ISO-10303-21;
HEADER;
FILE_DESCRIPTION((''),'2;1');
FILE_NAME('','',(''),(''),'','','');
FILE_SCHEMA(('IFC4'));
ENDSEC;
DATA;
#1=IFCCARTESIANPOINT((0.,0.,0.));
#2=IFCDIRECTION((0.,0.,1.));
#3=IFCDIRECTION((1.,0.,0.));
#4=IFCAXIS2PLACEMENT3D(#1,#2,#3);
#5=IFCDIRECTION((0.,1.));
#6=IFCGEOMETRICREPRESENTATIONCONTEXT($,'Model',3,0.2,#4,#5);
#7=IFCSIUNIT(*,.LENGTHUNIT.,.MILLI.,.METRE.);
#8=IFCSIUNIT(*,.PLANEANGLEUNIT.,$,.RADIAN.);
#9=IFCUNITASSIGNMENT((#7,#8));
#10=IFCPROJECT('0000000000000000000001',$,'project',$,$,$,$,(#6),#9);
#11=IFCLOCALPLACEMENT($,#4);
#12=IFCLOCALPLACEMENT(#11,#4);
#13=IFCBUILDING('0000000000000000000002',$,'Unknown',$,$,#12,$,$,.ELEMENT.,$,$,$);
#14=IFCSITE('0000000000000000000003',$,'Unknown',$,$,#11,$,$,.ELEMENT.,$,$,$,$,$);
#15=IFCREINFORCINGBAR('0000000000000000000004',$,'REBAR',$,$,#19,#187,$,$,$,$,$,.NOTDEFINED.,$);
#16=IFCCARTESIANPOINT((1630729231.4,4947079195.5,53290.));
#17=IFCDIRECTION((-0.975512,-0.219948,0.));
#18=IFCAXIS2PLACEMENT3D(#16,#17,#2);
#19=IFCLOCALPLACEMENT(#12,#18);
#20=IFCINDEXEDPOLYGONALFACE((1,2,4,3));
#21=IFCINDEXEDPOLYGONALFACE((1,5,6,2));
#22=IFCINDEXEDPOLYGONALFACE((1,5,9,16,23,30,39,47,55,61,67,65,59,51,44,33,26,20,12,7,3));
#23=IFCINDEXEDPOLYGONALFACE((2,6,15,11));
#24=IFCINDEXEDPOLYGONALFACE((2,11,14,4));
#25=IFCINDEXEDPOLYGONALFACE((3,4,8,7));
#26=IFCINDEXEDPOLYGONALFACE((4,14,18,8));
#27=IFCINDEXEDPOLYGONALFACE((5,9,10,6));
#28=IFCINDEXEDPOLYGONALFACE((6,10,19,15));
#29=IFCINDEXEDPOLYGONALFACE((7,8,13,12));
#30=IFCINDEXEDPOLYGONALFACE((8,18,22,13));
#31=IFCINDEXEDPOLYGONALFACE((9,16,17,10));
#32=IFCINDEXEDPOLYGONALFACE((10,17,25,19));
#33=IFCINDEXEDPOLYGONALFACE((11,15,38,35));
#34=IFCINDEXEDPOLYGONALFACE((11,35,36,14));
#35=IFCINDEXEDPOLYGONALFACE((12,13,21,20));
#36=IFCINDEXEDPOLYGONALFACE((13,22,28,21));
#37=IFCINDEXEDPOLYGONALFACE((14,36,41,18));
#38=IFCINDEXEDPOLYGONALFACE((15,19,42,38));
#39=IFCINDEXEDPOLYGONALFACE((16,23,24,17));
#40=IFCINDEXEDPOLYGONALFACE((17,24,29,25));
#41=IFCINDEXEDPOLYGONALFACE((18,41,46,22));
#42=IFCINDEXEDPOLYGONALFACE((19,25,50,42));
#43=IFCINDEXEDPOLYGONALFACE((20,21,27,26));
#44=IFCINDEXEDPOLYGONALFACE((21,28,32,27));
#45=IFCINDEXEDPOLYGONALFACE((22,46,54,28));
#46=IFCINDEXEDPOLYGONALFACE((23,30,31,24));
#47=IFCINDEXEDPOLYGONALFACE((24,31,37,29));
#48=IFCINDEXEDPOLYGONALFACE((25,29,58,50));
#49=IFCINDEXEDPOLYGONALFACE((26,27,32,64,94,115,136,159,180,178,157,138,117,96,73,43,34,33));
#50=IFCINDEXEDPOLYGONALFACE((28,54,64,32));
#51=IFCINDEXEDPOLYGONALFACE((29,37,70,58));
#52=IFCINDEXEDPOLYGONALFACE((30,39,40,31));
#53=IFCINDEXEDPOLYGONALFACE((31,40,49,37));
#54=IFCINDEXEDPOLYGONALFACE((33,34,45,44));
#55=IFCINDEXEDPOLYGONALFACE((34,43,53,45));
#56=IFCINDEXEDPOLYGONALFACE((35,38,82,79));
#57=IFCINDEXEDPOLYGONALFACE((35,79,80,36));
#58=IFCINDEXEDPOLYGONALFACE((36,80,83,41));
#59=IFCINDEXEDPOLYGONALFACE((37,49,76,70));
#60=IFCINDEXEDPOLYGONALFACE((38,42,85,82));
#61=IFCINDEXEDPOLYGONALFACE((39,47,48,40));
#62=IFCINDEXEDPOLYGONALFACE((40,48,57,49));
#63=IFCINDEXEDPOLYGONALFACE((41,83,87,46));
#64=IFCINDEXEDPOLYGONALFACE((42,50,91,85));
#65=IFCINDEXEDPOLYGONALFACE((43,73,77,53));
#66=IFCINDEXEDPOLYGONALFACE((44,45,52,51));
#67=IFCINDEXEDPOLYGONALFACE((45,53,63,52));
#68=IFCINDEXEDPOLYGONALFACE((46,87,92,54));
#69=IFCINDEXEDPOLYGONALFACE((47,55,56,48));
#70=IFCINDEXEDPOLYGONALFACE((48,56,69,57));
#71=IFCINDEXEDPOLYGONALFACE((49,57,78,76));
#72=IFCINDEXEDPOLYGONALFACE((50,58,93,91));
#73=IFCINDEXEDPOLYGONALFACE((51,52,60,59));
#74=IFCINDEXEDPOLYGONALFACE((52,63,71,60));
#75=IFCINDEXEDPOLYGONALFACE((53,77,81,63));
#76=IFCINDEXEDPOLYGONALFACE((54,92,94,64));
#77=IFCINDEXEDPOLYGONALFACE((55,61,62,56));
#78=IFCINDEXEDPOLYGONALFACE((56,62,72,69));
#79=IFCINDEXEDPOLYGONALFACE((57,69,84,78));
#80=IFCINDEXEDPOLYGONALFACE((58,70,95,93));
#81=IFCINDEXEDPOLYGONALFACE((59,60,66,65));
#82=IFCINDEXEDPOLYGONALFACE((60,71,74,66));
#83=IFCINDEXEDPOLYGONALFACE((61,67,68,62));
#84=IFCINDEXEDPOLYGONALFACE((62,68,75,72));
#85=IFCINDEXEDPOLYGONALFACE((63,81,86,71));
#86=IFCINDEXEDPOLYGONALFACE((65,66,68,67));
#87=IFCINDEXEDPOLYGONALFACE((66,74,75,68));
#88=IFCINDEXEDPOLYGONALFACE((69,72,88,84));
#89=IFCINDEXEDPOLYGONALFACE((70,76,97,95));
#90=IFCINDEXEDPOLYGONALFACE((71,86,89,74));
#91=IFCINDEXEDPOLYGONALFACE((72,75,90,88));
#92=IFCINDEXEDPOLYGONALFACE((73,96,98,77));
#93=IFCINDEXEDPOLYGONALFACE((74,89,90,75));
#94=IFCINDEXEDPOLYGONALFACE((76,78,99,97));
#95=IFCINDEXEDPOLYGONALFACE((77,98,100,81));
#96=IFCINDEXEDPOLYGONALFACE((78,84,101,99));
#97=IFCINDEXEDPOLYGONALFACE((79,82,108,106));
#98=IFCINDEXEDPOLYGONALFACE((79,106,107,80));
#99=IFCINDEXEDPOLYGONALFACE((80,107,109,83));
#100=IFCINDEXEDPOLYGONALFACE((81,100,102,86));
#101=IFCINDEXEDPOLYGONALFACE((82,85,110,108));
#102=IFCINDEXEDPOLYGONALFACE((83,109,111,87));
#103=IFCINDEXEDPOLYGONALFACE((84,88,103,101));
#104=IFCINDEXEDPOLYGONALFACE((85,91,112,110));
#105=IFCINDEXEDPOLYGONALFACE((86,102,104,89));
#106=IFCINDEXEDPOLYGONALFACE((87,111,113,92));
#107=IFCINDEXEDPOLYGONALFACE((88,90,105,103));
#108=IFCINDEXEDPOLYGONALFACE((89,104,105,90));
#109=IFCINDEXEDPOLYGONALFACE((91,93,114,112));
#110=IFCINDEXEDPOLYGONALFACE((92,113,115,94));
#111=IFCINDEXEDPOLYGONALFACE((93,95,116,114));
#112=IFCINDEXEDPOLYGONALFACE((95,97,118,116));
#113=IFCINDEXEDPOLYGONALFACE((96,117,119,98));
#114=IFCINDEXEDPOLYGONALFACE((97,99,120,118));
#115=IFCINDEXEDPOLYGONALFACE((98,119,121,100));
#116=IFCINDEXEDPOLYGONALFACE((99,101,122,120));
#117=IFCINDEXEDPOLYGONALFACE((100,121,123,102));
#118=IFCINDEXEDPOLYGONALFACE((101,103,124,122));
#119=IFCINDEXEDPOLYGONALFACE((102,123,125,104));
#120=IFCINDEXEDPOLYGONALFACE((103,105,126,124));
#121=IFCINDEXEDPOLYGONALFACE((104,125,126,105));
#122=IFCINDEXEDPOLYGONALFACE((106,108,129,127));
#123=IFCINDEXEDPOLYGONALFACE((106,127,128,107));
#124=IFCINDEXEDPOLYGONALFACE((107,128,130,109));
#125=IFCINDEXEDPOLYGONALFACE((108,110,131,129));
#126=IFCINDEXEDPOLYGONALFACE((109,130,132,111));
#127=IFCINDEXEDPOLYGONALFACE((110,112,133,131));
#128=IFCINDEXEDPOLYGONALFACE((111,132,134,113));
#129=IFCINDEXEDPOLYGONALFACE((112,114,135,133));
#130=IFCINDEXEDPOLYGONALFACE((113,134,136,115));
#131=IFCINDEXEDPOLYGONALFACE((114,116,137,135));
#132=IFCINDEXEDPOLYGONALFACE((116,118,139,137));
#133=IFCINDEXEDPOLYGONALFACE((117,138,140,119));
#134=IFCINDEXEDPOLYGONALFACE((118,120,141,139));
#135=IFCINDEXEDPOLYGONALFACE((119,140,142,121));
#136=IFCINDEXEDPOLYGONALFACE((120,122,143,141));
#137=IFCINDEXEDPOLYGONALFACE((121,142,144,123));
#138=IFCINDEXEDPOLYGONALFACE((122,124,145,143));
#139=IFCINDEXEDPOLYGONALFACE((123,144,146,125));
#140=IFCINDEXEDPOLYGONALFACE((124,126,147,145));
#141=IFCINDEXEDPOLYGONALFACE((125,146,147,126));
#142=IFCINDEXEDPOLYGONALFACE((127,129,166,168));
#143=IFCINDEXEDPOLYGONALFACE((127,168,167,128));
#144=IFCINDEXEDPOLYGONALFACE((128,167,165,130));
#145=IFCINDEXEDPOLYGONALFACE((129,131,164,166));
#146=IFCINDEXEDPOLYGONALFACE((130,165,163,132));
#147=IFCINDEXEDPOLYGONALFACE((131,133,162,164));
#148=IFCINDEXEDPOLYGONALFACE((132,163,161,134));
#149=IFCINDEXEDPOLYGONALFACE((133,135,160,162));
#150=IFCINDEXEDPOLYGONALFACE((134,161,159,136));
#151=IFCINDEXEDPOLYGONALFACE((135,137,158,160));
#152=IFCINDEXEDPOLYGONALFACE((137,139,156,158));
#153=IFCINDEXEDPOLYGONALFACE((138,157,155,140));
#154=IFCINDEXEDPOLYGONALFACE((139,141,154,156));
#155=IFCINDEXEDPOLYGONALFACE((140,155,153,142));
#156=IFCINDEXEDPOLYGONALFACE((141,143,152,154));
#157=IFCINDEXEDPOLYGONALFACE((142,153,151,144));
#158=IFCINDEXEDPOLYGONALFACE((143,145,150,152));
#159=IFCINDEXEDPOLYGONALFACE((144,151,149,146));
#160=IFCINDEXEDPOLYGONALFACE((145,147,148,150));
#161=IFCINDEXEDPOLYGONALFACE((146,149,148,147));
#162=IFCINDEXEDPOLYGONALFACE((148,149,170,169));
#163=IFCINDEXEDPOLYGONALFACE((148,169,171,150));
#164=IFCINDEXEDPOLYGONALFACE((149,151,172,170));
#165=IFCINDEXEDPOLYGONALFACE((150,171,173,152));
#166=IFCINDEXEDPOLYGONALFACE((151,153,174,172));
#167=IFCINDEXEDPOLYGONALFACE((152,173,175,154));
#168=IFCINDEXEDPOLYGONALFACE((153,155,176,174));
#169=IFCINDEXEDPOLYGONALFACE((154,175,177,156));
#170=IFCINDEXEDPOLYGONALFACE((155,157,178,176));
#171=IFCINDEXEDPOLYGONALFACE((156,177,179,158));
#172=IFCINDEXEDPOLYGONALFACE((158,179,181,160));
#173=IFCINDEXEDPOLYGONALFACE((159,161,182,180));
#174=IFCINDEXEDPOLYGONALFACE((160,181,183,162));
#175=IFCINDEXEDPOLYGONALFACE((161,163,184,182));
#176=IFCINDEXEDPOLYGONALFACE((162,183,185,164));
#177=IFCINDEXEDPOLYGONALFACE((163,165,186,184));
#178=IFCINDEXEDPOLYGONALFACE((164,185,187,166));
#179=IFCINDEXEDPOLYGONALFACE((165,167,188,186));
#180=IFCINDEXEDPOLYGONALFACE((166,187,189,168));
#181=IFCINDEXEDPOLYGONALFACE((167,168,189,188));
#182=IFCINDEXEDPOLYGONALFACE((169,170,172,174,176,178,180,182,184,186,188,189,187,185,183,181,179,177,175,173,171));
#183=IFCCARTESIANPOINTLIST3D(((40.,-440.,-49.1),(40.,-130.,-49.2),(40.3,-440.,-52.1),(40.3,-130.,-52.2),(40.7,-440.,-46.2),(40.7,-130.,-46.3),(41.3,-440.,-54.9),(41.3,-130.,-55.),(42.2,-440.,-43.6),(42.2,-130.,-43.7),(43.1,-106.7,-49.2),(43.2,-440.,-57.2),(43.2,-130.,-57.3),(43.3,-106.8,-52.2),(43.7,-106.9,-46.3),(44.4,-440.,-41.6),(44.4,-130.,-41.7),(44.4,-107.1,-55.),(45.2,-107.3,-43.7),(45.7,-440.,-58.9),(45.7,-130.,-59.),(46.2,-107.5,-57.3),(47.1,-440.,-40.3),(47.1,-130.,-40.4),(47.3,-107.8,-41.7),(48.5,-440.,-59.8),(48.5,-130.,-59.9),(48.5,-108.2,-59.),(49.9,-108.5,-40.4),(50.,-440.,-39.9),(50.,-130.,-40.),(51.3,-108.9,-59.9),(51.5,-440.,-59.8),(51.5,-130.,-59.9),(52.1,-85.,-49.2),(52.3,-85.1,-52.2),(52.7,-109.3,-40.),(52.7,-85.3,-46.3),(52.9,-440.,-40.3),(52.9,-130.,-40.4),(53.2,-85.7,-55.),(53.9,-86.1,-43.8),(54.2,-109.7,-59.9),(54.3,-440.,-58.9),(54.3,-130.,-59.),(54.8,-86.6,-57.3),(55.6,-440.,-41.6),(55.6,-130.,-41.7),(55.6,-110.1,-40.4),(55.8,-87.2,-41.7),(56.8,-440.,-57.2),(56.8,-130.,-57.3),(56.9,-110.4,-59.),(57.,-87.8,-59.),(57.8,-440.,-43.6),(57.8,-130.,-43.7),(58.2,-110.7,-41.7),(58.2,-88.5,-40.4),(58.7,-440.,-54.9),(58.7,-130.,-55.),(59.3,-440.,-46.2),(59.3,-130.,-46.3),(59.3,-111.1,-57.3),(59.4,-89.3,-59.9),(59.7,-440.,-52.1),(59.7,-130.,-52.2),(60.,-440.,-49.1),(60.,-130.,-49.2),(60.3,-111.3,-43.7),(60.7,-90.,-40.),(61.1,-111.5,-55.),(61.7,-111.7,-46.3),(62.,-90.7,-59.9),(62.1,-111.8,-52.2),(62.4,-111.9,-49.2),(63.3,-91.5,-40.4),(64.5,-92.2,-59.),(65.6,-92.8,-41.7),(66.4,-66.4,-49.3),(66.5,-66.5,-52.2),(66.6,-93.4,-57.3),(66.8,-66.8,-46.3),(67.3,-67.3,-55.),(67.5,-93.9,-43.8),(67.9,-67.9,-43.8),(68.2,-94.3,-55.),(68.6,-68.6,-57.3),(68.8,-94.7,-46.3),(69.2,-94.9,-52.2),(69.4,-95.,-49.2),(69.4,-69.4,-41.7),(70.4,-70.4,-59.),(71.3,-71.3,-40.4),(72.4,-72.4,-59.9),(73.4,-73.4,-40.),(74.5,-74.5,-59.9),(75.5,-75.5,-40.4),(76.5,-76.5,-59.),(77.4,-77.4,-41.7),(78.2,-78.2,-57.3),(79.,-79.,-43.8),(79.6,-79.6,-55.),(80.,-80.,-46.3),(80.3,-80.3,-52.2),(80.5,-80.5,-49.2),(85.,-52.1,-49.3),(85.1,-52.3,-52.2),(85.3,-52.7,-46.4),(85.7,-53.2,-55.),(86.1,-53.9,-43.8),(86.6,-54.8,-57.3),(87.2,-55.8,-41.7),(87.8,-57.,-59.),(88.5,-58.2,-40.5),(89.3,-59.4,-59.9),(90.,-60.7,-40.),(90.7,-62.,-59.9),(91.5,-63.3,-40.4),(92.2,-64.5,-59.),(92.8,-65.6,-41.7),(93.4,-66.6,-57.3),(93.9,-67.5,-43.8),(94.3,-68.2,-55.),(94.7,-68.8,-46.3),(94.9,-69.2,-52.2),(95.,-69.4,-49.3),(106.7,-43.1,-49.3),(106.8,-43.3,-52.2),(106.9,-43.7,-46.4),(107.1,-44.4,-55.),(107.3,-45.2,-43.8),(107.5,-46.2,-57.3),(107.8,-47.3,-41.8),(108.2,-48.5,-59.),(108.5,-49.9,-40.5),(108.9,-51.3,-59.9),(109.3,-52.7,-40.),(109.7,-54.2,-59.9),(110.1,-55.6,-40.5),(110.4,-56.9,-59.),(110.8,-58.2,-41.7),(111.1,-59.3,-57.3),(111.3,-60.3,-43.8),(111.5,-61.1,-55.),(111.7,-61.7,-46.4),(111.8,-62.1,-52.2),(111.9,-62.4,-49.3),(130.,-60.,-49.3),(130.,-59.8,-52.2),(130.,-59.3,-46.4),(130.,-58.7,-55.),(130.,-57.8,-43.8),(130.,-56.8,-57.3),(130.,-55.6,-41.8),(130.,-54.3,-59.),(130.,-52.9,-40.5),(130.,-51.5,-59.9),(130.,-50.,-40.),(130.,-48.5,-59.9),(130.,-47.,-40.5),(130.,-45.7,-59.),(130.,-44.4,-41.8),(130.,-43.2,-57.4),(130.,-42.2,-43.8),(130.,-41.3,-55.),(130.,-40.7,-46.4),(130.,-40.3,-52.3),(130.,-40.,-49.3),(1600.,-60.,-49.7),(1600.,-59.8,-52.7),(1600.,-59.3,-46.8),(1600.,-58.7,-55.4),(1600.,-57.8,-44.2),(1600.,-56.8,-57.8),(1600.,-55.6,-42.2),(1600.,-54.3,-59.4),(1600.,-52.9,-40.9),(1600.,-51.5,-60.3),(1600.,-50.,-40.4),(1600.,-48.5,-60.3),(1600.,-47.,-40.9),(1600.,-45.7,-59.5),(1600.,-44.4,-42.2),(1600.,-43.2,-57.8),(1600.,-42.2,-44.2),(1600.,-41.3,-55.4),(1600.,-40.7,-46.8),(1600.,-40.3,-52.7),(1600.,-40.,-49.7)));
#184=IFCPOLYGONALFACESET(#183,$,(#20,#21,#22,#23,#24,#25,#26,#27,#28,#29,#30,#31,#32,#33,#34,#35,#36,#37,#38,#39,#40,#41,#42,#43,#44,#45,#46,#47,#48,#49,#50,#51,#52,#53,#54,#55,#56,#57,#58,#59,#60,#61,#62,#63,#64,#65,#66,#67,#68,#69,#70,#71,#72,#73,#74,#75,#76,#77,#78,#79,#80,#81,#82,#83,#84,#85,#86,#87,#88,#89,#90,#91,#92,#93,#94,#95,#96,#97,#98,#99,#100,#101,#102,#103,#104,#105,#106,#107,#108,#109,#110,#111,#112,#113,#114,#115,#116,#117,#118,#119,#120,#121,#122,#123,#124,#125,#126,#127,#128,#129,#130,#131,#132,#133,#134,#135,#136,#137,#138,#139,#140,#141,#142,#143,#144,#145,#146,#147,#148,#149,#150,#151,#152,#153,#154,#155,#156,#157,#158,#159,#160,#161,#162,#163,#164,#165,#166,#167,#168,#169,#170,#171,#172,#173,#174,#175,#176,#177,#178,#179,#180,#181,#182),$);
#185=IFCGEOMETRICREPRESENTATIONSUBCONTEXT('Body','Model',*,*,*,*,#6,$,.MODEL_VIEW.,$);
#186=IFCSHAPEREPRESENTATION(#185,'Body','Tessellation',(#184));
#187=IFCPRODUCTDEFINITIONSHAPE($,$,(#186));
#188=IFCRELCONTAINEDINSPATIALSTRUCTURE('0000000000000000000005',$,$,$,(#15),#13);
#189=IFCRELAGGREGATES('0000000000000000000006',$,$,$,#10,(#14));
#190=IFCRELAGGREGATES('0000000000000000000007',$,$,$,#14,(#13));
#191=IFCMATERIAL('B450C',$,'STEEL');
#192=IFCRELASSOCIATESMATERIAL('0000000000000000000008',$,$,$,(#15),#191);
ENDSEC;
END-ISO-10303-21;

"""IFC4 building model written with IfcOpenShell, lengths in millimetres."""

from ifc_helpers import new_model, entity, si_unit, direction, frame, origin_with_axes, place, context, subcontext, project, spatial, material, element, save


model = new_model("IFC4")

# Units and contexts
model_context = context("Model", 3, precision=0.2, world=origin_with_axes(), true_north=direction((0.0, 1.0)))
body_context = subcontext(model_context, "Body", "Model", "MODEL_VIEW")
ifc_project = project(units=[si_unit("LENGTHUNIT", "METRE", prefix="MILLI"), si_unit("PLANEANGLEUNIT", "RADIAN")], contexts=[model_context])

# Site, building
site_placement = place(None, origin_with_axes())
site = spatial("IfcSite", under=ifc_project, at=site_placement, Name="Unknown", CompositionType="ELEMENT")
building_placement = place(site_placement, origin_with_axes())
building = spatial("IfcBuilding", under=site, at=building_placement, Name="Unknown", CompositionType="ELEMENT")

# Reinforcing bar
ifc_material = material(Name="B450C", Category="STEEL")
reinforcing_bar_1_placement = place(building_placement, frame((1630729231.4, 4947079195.5, 53290.0), z_axis=(-0.975512, -0.219948, 0.0), x_axis=(0.0, 0.0, 1.0)))
element("IfcReinforcingBar", 1, at=reinforcing_bar_1_placement, inside=building, material=ifc_material, Name="REBAR", PredefinedType="NOTDEFINED", context=body_context, shape_type="AdvancedSweptSolid", body=[
    entity("IfcSweptDiskSolid", entity("IfcIndexedPolyCurve", entity("IfcCartesianPointList3D", [[50.0, -440.0, -49.9], [50.0, -130.0, -50.0], [73.4, -73.4, -50.0], [130.0, -50.0, -50.0], [1600.0, -50.0, -50.4]]), [entity("IfcLineIndex", [1, 2]), entity("IfcArcIndex", [2, 3, 4]), entity("IfcLineIndex", [4, 5])]), 10.0),
])

save(model, "model.ifc")
